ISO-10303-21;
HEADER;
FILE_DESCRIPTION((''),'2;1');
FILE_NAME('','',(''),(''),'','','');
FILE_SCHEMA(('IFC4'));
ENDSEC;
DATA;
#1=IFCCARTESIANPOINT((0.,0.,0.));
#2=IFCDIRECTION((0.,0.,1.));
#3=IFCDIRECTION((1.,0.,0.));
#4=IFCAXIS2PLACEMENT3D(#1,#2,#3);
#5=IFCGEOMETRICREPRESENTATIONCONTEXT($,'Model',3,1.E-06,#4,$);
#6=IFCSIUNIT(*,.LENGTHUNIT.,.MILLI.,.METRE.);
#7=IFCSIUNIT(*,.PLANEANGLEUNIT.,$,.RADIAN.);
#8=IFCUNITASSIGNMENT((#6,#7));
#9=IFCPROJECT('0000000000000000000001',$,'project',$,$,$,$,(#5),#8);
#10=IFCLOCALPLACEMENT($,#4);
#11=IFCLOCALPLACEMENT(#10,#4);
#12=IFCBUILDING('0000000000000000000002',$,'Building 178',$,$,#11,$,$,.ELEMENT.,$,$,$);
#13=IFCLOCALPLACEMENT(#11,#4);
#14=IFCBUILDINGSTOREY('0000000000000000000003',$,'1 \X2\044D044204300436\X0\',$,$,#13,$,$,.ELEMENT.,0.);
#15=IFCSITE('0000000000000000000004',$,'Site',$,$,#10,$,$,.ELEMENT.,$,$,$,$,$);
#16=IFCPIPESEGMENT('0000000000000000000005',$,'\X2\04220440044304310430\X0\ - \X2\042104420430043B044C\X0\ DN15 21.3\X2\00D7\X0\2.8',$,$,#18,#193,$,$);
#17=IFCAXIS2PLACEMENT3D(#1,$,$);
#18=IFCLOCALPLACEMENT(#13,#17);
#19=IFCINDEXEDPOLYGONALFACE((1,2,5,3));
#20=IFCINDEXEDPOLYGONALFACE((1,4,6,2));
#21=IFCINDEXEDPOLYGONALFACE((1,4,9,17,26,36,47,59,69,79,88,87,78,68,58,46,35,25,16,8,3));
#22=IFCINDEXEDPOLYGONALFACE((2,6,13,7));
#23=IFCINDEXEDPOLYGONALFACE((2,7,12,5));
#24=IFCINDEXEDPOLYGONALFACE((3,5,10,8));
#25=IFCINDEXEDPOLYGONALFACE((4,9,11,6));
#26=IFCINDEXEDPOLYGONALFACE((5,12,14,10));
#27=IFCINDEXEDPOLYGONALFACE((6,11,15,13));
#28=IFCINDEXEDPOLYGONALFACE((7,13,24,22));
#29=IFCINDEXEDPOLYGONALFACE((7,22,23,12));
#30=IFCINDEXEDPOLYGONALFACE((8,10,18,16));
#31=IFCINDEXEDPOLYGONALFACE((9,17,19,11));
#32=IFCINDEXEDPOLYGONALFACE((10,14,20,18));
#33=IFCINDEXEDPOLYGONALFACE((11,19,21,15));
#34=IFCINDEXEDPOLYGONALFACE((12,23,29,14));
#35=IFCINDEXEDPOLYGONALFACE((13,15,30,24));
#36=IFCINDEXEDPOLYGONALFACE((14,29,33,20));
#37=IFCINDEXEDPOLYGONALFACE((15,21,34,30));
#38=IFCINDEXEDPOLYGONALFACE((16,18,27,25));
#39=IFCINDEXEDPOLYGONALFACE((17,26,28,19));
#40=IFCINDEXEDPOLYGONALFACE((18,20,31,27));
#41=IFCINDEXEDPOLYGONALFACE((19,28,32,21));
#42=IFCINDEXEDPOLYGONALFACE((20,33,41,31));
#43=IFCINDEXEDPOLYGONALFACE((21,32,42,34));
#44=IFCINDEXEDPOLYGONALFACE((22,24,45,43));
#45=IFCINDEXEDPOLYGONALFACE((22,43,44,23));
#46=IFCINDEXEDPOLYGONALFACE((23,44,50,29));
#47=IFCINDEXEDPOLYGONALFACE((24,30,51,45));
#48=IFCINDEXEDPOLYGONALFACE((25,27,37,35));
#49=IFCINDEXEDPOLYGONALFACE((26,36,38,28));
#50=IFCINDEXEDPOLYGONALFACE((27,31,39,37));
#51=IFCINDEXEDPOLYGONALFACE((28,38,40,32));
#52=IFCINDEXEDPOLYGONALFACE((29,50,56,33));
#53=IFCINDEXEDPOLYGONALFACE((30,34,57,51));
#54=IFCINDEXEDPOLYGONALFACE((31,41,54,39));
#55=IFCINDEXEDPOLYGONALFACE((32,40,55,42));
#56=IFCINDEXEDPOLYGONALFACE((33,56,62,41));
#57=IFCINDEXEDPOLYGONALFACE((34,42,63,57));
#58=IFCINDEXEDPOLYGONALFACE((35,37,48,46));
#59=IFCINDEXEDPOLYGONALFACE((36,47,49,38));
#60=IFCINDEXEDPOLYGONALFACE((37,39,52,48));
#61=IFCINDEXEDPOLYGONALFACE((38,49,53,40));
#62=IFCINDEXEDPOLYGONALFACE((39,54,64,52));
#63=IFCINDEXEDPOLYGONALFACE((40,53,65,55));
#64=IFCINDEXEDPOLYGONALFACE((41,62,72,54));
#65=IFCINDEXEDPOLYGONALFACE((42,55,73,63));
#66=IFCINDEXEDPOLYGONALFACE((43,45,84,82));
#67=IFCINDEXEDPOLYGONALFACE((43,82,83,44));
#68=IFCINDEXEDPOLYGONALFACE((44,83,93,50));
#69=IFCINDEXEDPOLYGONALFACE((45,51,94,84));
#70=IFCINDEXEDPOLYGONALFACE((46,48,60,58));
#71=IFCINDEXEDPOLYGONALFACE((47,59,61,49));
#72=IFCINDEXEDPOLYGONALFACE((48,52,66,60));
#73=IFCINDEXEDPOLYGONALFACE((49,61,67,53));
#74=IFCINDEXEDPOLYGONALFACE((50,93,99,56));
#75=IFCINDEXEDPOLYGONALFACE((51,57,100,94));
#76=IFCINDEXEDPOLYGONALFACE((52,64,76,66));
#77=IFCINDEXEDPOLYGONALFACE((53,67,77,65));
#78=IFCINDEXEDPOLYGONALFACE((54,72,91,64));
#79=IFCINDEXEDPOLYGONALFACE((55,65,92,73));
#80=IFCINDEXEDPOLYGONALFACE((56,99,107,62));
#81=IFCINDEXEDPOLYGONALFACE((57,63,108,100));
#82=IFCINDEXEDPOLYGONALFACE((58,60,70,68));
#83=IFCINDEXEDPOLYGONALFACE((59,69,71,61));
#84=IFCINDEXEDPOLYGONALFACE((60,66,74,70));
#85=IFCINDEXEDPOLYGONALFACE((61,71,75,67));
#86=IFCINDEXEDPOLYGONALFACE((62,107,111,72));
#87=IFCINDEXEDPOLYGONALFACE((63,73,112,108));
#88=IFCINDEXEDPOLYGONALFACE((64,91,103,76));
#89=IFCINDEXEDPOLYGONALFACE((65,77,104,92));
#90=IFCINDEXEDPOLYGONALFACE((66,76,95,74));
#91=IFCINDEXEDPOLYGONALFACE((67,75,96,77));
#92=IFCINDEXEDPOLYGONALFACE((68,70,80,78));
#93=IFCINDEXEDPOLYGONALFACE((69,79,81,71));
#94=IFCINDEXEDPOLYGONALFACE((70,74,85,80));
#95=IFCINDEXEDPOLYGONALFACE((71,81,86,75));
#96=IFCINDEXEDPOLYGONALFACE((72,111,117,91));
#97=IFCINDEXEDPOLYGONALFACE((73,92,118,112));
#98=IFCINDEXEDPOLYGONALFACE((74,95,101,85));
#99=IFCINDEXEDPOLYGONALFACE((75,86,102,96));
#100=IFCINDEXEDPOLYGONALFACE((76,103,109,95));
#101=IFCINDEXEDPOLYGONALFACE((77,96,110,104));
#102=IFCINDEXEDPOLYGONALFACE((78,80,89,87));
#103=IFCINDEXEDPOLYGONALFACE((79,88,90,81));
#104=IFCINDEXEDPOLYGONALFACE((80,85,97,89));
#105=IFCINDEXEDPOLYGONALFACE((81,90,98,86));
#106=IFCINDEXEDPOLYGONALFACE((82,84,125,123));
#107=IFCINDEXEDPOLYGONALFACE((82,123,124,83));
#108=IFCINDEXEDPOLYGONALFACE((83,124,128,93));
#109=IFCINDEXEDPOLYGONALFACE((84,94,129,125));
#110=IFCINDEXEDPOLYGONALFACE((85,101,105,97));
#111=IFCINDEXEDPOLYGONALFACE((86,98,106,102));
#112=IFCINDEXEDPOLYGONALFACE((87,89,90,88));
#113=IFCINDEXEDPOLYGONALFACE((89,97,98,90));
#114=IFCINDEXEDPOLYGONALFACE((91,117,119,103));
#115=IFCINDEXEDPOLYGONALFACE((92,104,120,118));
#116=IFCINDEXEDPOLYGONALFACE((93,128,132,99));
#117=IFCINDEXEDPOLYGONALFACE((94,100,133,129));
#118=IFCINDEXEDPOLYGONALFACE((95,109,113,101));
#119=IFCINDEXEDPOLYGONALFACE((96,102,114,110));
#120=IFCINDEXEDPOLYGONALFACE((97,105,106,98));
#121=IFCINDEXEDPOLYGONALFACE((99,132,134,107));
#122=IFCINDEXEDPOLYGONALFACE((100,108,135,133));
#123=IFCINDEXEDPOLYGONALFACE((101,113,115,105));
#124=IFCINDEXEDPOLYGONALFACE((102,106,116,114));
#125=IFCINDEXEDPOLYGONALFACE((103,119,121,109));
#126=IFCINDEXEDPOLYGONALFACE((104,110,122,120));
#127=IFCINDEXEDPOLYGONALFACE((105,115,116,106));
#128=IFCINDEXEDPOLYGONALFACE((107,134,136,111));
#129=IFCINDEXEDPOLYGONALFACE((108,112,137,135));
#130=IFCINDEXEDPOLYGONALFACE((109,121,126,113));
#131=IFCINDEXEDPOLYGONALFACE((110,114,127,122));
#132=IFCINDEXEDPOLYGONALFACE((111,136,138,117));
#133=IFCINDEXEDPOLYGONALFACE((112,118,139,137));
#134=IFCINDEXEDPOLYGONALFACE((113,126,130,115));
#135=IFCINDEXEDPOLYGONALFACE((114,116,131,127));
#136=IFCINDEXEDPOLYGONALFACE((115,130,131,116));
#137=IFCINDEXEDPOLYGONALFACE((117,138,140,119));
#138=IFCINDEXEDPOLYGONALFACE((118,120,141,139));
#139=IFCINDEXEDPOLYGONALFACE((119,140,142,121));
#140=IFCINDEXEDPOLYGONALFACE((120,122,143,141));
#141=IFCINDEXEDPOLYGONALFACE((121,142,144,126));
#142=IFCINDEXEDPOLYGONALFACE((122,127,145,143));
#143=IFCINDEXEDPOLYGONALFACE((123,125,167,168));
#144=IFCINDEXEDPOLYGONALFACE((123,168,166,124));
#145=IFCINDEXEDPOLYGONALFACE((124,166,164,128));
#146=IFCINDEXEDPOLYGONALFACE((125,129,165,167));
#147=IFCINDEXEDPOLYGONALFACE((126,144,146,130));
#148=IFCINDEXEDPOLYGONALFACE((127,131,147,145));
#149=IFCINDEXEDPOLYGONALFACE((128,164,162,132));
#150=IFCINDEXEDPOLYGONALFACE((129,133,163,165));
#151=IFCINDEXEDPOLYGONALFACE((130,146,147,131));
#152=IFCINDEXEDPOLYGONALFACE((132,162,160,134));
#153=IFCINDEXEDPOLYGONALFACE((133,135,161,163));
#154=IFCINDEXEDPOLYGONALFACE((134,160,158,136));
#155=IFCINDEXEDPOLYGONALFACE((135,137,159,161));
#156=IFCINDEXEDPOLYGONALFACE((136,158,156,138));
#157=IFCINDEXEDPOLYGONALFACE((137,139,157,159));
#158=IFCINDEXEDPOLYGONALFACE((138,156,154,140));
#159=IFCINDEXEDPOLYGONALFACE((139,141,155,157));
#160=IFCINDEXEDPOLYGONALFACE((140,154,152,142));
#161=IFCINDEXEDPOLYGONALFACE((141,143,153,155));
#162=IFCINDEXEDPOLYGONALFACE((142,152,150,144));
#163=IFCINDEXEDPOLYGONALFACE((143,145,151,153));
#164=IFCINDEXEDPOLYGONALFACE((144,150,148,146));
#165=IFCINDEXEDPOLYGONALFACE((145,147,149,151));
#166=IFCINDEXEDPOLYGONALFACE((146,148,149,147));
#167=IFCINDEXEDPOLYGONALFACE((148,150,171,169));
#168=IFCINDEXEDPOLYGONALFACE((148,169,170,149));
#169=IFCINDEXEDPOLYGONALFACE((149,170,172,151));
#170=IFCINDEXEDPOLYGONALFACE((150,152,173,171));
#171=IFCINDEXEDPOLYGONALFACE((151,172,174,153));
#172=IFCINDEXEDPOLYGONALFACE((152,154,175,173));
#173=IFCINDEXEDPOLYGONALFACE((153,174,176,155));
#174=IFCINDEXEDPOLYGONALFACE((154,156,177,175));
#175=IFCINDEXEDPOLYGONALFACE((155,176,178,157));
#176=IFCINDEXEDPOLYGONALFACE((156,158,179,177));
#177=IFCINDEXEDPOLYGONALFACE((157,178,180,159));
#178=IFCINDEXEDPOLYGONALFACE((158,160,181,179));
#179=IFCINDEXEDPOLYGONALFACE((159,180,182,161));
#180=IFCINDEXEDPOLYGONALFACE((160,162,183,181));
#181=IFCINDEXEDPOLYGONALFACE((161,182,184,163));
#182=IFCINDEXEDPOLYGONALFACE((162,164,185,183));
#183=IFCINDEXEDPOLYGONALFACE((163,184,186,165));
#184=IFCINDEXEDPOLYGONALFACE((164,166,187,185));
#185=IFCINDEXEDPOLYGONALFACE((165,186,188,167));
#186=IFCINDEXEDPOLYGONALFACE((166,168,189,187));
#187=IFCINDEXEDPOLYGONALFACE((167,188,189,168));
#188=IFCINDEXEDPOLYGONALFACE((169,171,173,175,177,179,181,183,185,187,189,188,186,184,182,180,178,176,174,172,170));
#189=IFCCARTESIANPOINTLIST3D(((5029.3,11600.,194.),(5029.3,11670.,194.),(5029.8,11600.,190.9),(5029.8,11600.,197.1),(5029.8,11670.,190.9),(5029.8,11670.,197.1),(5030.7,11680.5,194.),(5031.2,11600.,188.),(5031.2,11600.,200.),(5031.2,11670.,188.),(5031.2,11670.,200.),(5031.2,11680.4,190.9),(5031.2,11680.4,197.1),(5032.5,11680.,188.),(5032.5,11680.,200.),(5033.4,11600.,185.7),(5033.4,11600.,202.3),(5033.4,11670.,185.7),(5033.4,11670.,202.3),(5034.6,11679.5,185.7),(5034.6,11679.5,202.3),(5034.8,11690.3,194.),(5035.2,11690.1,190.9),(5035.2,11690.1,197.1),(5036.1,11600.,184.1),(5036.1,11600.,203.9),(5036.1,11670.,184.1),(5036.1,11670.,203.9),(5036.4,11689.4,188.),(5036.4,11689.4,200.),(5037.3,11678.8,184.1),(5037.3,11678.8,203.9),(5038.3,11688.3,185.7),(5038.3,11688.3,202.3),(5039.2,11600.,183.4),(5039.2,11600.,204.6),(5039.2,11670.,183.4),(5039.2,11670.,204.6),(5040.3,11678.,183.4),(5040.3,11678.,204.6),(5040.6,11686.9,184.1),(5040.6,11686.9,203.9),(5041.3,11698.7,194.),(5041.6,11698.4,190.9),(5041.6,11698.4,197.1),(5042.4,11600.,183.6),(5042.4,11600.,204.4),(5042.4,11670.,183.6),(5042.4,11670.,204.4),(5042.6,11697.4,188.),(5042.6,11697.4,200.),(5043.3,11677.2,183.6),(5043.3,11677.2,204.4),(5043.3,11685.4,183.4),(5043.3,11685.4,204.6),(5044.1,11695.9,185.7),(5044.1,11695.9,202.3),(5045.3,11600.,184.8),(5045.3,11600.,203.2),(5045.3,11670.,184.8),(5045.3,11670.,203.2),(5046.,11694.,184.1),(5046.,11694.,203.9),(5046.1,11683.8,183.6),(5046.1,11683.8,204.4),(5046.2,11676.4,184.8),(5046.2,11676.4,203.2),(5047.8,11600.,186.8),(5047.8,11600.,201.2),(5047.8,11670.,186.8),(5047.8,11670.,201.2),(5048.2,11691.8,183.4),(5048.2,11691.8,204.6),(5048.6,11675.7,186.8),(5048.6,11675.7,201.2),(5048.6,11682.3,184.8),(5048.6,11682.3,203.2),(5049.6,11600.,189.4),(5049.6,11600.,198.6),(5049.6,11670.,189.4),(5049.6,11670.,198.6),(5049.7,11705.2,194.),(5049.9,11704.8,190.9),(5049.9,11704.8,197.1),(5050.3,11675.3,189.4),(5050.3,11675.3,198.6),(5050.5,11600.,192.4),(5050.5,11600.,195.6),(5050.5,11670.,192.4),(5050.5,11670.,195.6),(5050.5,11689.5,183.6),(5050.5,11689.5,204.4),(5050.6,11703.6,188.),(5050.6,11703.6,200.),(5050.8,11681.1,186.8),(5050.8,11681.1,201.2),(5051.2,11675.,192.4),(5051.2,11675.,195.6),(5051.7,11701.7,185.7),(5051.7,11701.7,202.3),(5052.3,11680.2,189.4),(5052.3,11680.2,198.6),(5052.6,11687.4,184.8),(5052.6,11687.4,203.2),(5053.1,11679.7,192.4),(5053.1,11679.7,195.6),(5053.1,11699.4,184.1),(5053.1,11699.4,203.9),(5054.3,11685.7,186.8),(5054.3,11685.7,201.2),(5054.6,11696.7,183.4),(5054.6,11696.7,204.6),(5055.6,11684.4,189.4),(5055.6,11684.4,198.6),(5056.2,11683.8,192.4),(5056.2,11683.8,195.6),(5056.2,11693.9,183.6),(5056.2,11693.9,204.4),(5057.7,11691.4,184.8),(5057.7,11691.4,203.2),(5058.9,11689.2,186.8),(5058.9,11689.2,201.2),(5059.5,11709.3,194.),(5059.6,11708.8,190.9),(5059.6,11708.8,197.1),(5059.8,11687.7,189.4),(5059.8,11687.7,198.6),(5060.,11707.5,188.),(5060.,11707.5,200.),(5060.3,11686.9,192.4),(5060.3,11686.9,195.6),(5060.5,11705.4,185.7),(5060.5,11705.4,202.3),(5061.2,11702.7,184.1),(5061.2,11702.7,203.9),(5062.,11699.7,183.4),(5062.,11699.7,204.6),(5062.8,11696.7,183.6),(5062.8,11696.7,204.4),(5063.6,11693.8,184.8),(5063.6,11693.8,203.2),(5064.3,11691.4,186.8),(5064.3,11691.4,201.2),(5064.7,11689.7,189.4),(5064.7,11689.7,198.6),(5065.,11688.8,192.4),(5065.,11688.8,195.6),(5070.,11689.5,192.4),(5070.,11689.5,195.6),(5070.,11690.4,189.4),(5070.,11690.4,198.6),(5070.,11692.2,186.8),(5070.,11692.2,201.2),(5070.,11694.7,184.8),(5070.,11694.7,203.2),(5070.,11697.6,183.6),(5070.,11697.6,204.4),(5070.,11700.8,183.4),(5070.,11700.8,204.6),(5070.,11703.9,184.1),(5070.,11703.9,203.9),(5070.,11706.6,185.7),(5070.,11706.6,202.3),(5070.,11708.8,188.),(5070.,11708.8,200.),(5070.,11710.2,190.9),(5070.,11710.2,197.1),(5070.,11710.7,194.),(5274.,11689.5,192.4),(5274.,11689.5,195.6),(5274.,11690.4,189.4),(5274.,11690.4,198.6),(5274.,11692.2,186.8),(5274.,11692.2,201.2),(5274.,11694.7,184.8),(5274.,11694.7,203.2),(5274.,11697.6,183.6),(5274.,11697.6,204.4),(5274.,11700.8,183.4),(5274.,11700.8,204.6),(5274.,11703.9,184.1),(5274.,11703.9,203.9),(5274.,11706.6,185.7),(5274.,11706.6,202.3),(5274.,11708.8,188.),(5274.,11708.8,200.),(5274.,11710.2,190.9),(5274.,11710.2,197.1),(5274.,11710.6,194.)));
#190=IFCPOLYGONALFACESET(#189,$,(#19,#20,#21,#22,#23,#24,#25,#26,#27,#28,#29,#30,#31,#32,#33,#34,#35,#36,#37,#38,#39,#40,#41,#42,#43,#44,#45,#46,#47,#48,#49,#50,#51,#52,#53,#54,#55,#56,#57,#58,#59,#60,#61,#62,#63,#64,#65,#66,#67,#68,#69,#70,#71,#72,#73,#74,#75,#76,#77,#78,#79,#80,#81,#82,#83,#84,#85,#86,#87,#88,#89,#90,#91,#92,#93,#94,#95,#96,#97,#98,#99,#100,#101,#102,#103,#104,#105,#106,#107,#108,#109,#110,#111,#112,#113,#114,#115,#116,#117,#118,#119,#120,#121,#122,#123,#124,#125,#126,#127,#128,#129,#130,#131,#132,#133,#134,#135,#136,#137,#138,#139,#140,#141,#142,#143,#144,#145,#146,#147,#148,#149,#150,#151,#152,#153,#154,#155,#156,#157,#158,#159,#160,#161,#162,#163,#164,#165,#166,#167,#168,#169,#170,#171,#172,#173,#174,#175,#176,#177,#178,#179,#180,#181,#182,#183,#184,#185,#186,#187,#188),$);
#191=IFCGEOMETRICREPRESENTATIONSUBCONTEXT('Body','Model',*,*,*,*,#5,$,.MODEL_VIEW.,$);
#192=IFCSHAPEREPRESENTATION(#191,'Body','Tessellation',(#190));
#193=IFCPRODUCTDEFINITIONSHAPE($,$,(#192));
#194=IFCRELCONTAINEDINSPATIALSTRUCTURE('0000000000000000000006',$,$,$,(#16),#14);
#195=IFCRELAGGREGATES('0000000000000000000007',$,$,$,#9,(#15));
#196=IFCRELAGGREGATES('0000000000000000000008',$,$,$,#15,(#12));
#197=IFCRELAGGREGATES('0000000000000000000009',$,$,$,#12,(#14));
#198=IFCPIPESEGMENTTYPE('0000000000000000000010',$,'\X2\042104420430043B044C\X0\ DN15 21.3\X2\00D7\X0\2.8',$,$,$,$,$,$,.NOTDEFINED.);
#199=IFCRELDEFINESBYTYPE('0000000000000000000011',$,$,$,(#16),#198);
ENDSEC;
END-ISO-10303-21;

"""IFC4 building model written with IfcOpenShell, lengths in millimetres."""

from ifc_helpers import new_model, entity, si_unit, frame, origin_with_axes, place, context, subcontext, project, spatial, source, transform, mapped, type_object, element, save


model = new_model("IFC4")

# Units and contexts
model_context = context("Model", 3, precision=1e-06, world=origin_with_axes())
body_context = subcontext(model_context, "Body", "Model", "MODEL_VIEW")
ifc_project = project(units=[si_unit("LENGTHUNIT", "METRE", prefix="MILLI"), si_unit("PLANEANGLEUNIT", "RADIAN")], contexts=[model_context])

# Site, building, storey
site_placement = place(None, origin_with_axes())
site = spatial("IfcSite", under=ifc_project, at=site_placement, Name="Site", CompositionType="ELEMENT")
building_placement = place(site_placement, origin_with_axes())
building = spatial("IfcBuilding", under=site, at=building_placement, Name="Building 178", CompositionType="ELEMENT")
storey_placement = place(building_placement, origin_with_axes())
storey = spatial("IfcBuildingStorey", under=building, at=storey_placement, Name="1 этаж", CompositionType="ELEMENT", Elevation=0.0)

# Pipe segment
pipe_segment_type = type_object("IfcPipeSegmentType", Name="Сталь DN15 21.3×2.8", PredefinedType="NOTDEFINED")
shared_shape_1 = source(origin_with_axes(), body_context, "Body", "AdvancedSweptSolid", [
    entity("IfcSweptDiskSolid", entity("IfcIndexedPolyCurve", entity("IfcCartesianPointList3D", [[0.0, 0.0, 0.0], [0.0, 0.0, -70.0], [8.8, 0.0, -91.2], [30.0, 0.0, -100.0], [234.0, 0.0, -100.0]]), [entity("IfcLineIndex", [1, 2]), entity("IfcArcIndex", [2, 3, 4]), entity("IfcLineIndex", [4, 5])]), 10.7),
])
for number, where, z_axis, x_axis, name in (
    (1, (5040.0, 11600.0, 194.0), (0.0, -1.0, 0.0), (1.0, 0.0, 0.0), "Труба - Сталь DN15 21.3×2.8"),
):
    element("IfcPipeSegment", number, at=place(storey_placement, frame(where, z_axis=z_axis, x_axis=x_axis)), inside=storey, type_object=pipe_segment_type, Name=name, context=body_context, shape_type="MappedRepresentation", body=[
        mapped(shared_shape_1, transform((0.0, 0.0, 0.0), x_axis=(1.0, 0.0, 0.0), y_axis=(0.0, 1.0, 0.0), z_axis=(0.0, 0.0, 1.0), scale=1.0)),
    ])

save(model, "model.ifc")
